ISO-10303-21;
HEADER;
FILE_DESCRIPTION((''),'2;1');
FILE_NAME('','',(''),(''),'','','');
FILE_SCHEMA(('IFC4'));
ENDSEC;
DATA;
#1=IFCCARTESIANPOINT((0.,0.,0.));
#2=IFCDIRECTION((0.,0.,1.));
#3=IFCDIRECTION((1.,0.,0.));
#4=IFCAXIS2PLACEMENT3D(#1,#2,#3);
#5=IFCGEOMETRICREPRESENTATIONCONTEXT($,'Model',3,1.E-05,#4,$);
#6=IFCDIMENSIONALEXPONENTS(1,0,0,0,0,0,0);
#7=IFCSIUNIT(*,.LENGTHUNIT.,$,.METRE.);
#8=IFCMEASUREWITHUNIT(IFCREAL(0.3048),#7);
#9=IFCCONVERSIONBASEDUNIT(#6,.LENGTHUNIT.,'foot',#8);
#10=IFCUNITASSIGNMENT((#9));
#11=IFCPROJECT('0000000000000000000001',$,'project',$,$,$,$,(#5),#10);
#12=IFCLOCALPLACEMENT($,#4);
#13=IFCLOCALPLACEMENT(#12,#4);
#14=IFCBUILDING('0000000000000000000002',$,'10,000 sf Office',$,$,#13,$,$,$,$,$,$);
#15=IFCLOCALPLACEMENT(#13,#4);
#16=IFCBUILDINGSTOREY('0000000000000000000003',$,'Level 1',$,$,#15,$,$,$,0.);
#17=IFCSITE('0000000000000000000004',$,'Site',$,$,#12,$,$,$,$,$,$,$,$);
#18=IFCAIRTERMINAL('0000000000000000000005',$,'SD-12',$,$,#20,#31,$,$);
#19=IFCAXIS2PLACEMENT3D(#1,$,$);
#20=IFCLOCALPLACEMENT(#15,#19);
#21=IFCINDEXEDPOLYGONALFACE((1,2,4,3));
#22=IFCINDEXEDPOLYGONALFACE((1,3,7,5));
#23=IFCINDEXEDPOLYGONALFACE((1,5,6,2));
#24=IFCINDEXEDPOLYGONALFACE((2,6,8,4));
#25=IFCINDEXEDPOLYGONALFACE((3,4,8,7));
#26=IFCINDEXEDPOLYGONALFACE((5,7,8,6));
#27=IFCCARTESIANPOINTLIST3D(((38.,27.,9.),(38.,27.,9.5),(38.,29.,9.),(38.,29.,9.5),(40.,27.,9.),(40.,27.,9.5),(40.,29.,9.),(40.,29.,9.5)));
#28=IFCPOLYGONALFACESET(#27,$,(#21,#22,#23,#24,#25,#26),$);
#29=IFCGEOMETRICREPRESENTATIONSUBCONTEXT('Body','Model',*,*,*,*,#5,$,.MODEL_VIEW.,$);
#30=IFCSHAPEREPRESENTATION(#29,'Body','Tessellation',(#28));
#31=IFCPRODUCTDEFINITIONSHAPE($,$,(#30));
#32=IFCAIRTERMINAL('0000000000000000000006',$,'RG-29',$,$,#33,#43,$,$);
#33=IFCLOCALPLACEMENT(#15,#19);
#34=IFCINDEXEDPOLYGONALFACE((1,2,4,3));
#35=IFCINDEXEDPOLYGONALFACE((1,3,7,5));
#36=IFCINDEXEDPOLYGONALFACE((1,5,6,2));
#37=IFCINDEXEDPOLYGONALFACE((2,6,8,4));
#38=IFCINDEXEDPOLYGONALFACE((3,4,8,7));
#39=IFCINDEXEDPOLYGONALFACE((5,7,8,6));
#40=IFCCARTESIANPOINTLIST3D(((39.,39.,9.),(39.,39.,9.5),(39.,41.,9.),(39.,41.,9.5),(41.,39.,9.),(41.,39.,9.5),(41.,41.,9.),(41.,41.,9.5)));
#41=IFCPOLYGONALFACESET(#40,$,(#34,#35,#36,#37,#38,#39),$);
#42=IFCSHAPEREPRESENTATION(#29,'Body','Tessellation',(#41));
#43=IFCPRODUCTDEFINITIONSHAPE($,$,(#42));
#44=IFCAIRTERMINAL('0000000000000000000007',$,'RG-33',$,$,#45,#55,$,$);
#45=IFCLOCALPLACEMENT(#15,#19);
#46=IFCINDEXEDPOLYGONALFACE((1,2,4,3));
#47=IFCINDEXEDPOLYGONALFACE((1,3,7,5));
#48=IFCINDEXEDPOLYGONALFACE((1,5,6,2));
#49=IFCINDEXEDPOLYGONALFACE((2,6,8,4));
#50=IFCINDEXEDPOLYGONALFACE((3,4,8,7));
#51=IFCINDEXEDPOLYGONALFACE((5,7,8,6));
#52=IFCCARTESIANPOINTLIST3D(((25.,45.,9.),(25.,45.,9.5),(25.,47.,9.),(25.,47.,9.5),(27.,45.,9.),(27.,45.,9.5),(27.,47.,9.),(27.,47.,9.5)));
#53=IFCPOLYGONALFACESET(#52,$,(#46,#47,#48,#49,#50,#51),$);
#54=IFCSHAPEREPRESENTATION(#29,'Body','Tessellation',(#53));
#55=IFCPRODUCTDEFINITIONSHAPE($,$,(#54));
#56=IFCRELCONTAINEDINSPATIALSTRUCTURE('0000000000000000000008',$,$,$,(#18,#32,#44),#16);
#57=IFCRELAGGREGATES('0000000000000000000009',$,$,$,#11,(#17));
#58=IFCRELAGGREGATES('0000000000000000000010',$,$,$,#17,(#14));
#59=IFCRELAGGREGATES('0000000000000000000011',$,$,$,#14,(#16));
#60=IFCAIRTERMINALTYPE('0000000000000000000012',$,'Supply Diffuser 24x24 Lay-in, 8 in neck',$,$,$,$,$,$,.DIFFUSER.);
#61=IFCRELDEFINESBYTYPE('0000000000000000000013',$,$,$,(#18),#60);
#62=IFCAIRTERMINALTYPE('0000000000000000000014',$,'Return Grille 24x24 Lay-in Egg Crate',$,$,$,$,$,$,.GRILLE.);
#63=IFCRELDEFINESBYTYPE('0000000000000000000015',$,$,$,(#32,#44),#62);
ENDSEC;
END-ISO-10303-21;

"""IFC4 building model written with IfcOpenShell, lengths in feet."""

from ifc_helpers import new_model, entity, si_unit, converted_unit, frame, origin_with_axes, place, context, subcontext, project, spatial, rectangle, extrude, type_object, element, save


model = new_model("IFC4")

# Units and contexts
model_context = context("Model", 3, precision=1e-05, world=origin_with_axes())
body_context = subcontext(model_context, "Body", "Model", "MODEL_VIEW")
ifc_project = project(units=[converted_unit("LENGTHUNIT", "foot", entity("IfcReal", 0.3048), si_unit("LENGTHUNIT", "METRE"), dimensions=[1, 0, 0, 0, 0, 0, 0])], contexts=[model_context])

# Site, building, storey
site_placement = place(None, origin_with_axes())
site = spatial("IfcSite", under=ifc_project, at=site_placement, Name="Site")
building_placement = place(site_placement, origin_with_axes())
building = spatial("IfcBuilding", under=site, at=building_placement, Name="10,000 sf Office")
storey_placement = place(building_placement, origin_with_axes())
storey = spatial("IfcBuildingStorey", under=building, at=storey_placement, Name="Level 1", Elevation=0.0)

# Air terminals
air_terminal_type_1 = type_object("IfcAirTerminalType", Name="Supply Diffuser 24x24 Lay-in, 8 in neck", PredefinedType="DIFFUSER")
for number, where, z_axis, x_axis, name in (
    (1, (39.0, 28.0, 9.0), (0.0, 0.0, 1.0), (1.0, 0.0, 0.0), "SD-12"),
):
    element("IfcAirTerminal", number, at=place(storey_placement, frame(where, z_axis=z_axis, x_axis=x_axis)), inside=storey, type_object=air_terminal_type_1, Name=name, context=body_context, shape_type="SweptSolid", body=[
        extrude(rectangle(XDim=2.0, YDim=2.0), None, (0.0, 0.0, 1.0), 0.5),
    ])
air_terminal_type_2 = type_object("IfcAirTerminalType", Name="Return Grille 24x24 Lay-in Egg Crate", PredefinedType="GRILLE")
for number, where, z_axis, x_axis, name in (
    (2, (40.0, 40.0, 9.0), (0.0, 0.0, 1.0), (1.0, 0.0, 0.0), "RG-29"),
    (3, (26.0, 46.0, 9.0), (0.0, 0.0, 1.0), (1.0, 0.0, 0.0), "RG-33"),
):
    element("IfcAirTerminal", number, at=place(storey_placement, frame(where, z_axis=z_axis, x_axis=x_axis)), inside=storey, type_object=air_terminal_type_2, Name=name, context=body_context, shape_type="SweptSolid", body=[
        extrude(rectangle(XDim=2.0, YDim=2.0), None, (0.0, 0.0, 1.0), 0.5),
    ])

save(model, "model.ifc")
